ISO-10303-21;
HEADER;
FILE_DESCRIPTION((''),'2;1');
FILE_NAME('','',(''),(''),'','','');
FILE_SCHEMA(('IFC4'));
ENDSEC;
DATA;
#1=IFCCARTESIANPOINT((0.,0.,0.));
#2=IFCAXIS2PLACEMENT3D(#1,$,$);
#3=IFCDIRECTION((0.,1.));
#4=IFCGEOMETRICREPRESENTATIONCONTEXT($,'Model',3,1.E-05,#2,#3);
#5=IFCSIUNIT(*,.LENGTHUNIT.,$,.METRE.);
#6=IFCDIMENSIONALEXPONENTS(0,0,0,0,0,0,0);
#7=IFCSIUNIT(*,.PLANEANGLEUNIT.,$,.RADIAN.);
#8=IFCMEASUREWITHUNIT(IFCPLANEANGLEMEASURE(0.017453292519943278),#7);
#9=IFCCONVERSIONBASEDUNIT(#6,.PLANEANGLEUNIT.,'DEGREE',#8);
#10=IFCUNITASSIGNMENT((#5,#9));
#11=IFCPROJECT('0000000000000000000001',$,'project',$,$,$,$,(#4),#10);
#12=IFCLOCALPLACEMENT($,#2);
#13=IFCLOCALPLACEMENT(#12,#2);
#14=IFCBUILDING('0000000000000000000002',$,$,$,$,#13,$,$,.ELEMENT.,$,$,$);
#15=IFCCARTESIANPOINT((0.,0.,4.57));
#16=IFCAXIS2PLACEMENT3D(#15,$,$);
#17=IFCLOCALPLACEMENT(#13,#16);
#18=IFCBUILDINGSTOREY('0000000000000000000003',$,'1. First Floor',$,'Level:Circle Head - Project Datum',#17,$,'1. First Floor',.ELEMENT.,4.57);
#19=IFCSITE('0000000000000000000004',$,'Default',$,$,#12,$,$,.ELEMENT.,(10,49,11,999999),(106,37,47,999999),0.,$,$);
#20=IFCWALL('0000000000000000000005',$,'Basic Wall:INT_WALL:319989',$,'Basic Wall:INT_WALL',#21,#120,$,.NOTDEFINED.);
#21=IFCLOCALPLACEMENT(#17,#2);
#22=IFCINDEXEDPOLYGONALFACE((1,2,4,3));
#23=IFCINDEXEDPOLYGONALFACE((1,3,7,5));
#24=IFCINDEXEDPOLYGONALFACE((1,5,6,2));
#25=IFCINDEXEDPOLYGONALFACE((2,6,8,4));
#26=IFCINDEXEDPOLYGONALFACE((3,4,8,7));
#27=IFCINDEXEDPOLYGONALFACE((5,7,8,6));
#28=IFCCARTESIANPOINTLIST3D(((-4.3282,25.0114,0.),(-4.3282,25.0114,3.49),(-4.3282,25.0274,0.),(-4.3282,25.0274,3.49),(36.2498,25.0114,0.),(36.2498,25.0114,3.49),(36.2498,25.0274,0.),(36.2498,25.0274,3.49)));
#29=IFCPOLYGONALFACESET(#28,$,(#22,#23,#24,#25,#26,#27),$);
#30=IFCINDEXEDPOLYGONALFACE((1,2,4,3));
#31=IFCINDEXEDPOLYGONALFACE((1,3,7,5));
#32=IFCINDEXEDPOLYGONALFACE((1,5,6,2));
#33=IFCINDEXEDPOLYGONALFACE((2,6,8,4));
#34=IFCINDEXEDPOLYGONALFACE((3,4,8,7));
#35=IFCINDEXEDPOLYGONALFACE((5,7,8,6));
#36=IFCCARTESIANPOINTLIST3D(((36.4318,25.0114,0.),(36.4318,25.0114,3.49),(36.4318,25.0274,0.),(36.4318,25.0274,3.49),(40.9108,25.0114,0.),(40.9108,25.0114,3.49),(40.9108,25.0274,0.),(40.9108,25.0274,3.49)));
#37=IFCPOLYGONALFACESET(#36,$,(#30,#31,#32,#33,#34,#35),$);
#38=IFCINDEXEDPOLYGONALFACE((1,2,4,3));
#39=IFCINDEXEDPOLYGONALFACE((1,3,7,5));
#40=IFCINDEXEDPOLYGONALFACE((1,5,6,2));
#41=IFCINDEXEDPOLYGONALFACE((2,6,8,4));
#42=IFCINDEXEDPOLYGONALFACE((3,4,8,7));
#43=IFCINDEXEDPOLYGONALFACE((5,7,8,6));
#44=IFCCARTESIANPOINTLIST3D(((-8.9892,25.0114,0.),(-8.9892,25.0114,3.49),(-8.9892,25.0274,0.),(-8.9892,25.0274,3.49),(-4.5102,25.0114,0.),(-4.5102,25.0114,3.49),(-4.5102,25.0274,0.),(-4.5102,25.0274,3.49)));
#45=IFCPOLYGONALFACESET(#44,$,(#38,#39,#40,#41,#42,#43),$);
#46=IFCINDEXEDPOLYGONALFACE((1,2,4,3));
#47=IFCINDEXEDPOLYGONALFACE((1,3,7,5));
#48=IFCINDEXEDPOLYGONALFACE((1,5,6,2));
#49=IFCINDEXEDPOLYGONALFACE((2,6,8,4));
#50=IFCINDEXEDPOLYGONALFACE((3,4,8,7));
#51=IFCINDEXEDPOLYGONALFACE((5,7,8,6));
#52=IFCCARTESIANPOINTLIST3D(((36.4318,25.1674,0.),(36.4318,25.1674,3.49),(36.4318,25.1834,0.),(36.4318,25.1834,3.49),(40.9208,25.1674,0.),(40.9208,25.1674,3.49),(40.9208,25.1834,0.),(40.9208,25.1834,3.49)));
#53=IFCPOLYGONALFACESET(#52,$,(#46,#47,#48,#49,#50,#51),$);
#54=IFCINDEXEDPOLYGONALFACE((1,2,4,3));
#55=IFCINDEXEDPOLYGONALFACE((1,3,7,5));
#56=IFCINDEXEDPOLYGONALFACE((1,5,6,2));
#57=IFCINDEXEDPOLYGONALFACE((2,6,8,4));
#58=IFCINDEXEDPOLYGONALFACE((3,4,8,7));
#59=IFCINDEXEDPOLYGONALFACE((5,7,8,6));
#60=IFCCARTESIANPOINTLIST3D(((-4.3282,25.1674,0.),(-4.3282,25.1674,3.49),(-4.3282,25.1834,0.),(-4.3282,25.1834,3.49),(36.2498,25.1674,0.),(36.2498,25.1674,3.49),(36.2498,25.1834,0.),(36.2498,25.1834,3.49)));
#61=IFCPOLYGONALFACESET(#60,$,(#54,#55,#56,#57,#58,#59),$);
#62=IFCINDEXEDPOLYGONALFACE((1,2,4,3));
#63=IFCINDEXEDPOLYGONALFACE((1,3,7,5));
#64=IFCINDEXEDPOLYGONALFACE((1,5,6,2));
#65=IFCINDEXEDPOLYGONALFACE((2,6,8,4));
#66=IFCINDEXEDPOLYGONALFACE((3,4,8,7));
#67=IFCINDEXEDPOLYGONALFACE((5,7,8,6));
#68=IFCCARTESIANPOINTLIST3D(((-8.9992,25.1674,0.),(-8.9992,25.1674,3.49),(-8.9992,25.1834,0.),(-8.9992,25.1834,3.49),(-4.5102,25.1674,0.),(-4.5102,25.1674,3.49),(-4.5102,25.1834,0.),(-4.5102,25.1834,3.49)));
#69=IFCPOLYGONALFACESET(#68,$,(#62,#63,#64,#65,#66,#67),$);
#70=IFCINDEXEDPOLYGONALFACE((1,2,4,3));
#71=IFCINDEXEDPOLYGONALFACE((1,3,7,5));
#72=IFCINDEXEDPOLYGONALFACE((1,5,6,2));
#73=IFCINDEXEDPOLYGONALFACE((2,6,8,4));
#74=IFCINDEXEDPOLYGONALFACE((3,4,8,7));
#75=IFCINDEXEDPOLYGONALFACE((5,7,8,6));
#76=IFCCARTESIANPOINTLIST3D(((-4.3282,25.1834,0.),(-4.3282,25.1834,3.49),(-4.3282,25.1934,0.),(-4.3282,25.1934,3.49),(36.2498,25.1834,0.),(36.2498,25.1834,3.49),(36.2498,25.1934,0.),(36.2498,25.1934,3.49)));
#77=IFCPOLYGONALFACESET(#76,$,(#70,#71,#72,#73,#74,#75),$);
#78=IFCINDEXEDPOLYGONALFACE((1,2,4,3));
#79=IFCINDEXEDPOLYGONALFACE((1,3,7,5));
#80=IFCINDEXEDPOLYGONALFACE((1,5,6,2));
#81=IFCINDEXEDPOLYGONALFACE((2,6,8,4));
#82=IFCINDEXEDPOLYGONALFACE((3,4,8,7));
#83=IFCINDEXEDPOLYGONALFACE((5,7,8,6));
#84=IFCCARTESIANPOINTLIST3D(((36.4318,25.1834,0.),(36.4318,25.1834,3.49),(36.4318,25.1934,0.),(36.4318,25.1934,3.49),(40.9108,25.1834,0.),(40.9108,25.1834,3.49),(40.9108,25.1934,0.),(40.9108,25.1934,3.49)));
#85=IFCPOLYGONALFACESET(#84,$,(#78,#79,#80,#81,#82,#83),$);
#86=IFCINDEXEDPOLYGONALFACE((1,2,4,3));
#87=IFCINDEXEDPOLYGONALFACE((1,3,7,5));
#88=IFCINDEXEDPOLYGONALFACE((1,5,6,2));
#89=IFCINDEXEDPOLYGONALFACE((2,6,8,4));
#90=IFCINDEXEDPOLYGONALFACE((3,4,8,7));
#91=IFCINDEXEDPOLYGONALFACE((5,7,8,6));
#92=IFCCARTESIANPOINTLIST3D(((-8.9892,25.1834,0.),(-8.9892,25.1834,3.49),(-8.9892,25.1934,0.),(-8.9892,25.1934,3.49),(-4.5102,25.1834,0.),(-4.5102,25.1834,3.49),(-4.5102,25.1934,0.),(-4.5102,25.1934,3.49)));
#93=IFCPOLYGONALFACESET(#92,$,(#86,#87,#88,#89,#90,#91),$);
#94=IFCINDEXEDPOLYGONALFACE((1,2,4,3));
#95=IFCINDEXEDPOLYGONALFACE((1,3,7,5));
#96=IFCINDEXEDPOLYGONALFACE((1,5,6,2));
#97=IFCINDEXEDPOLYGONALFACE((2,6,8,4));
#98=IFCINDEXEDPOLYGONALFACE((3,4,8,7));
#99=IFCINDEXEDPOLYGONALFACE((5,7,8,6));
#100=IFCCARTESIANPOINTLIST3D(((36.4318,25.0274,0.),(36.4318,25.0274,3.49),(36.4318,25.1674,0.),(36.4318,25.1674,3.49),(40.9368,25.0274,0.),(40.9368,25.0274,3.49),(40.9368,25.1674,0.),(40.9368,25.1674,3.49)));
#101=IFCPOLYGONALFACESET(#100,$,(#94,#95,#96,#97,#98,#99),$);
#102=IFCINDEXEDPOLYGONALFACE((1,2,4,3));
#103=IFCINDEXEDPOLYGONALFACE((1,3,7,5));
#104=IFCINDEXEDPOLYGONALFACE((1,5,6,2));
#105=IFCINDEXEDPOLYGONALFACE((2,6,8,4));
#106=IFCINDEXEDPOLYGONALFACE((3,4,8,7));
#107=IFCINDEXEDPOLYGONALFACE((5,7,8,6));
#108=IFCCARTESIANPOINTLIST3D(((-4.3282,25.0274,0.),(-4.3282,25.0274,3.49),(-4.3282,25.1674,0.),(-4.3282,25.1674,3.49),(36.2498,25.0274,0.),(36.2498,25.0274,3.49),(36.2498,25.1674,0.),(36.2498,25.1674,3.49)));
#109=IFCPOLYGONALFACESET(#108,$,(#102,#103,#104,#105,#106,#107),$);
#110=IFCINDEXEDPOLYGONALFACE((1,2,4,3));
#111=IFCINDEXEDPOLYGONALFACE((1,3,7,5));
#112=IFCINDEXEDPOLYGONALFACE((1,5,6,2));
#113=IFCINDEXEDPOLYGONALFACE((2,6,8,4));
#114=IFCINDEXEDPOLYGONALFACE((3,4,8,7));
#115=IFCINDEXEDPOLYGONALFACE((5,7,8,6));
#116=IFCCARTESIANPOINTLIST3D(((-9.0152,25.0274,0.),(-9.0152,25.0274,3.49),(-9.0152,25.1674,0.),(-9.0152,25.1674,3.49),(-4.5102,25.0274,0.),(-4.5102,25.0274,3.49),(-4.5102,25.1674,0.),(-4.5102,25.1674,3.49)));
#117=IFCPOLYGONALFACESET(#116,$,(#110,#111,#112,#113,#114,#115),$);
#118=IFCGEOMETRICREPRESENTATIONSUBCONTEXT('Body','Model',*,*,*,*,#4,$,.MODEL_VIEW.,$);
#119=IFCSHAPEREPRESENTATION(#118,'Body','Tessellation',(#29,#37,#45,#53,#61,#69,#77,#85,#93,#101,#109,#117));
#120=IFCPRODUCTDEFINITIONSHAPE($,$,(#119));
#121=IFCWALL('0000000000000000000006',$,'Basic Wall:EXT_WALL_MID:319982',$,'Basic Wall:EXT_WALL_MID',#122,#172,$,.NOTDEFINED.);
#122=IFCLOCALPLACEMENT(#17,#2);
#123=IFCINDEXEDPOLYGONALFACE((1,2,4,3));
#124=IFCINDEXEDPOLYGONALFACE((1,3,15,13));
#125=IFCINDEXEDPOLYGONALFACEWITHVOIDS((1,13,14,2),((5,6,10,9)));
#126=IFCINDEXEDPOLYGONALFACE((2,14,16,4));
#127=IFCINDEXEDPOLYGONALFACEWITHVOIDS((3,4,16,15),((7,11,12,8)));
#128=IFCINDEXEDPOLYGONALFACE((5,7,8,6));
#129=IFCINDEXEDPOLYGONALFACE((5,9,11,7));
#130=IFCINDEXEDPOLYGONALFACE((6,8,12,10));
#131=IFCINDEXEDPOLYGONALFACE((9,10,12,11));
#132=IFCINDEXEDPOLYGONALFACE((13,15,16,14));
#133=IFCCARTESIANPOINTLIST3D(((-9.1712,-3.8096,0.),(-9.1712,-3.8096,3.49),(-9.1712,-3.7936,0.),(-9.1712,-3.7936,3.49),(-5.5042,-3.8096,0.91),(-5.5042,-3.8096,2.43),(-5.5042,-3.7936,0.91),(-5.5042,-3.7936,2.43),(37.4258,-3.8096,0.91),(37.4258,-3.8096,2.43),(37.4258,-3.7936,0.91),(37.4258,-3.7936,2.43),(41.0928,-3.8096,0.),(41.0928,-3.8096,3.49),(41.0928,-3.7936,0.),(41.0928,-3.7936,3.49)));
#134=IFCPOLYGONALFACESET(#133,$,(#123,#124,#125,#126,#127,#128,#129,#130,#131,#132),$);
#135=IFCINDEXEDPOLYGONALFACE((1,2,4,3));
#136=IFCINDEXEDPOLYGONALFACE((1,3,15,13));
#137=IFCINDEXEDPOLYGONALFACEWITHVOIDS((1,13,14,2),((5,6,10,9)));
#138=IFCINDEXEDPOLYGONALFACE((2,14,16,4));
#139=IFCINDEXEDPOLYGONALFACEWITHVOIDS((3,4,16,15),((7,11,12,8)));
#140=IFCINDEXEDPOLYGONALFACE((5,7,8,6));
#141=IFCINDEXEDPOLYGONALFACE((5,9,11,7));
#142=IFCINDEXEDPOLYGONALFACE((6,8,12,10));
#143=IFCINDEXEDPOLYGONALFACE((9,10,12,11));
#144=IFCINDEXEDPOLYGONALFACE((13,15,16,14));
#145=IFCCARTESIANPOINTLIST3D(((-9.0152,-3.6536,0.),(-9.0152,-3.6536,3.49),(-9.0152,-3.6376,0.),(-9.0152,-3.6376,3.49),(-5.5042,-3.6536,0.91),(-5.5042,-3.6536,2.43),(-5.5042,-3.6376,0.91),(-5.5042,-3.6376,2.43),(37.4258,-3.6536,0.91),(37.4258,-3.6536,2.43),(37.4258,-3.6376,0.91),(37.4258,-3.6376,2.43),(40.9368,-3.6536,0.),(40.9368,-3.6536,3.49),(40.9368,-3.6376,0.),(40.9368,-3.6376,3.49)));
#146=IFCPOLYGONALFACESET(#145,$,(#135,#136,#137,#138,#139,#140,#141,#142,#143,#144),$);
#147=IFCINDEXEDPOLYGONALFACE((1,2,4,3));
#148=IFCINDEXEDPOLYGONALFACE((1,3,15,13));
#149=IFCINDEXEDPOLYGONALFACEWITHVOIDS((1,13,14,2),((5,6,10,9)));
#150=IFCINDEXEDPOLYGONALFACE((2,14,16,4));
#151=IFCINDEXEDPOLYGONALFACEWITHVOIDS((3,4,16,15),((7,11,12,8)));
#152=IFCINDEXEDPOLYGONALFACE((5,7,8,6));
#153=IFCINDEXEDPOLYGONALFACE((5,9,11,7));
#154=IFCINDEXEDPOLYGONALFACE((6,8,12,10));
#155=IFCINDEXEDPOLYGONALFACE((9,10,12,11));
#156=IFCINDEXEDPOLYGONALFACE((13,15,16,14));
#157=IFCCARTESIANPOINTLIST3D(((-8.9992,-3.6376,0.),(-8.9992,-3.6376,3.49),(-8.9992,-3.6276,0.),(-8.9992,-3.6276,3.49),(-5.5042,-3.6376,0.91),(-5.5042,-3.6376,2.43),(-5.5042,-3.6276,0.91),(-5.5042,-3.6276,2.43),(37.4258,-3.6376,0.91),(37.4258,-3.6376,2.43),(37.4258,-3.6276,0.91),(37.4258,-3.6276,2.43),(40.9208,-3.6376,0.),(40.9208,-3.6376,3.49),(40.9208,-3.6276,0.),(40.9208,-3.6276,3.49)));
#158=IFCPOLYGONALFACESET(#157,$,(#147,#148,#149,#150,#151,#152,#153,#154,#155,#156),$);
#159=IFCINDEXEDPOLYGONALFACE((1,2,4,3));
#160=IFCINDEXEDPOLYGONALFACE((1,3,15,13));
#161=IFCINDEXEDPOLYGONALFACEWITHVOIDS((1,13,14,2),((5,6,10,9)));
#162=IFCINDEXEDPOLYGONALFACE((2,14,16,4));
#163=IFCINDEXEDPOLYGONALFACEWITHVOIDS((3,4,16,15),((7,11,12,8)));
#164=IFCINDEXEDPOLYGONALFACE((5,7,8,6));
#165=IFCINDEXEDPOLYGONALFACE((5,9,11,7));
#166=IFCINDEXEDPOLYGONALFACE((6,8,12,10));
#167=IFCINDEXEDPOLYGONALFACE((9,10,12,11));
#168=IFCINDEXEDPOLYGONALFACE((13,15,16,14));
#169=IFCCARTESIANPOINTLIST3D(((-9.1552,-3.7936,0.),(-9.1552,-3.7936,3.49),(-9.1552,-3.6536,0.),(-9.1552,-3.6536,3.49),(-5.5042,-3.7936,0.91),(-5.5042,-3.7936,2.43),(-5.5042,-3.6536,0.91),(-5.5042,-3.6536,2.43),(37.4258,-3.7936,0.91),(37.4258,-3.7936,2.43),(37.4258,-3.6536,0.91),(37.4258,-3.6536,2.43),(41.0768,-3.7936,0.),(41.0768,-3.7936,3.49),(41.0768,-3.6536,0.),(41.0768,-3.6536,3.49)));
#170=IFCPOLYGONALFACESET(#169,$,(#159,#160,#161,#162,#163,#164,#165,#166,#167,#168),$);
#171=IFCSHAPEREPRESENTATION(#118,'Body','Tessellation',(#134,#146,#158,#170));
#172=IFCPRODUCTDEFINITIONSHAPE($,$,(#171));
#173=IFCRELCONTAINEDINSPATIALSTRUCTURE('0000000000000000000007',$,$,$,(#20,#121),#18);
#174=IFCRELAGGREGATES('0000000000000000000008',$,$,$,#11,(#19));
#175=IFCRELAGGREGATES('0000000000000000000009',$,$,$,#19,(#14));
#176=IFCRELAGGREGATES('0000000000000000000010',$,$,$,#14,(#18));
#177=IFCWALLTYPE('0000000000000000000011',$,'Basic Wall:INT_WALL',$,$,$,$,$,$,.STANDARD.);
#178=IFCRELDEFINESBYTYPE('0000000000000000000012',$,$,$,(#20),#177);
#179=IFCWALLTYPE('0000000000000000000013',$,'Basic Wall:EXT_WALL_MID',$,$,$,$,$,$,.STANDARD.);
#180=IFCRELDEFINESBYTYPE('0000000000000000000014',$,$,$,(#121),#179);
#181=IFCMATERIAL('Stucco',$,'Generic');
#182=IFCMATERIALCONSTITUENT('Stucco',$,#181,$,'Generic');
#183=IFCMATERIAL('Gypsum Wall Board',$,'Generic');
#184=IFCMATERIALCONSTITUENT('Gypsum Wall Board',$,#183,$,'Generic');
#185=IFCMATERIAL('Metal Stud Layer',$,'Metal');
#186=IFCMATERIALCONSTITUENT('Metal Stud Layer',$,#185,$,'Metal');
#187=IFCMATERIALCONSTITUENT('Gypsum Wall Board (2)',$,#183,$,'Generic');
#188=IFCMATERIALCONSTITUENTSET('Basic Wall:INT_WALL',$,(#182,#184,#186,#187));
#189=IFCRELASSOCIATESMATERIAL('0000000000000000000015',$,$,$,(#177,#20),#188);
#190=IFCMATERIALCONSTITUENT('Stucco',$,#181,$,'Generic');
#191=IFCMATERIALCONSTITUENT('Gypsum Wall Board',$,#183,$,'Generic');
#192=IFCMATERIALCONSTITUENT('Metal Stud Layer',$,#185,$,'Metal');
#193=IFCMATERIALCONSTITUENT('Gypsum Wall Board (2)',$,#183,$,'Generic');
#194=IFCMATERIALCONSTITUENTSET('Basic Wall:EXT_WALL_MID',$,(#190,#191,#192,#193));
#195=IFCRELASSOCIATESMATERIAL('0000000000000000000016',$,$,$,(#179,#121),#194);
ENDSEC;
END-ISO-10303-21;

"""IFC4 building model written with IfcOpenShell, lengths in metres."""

from ifc_helpers import new_model, entity, si_unit, converted_unit, direction, frame, origin, place, context, subcontext, project, spatial, indexed_curve, outline, extrude, material, constituent, constituent_set, type_object, element, save


model = new_model("IFC4")

# Units and contexts
model_context = context("Model", 3, precision=1e-05, world=origin(), true_north=direction((0.0, 1.0)))
body_context = subcontext(model_context, "Body", "Model", "MODEL_VIEW")
ifc_project = project(units=[si_unit("LENGTHUNIT", "METRE"), converted_unit("PLANEANGLEUNIT", "DEGREE", entity("IfcPlaneAngleMeasure", 0.017453292519943278), si_unit("PLANEANGLEUNIT", "RADIAN"), dimensions=[0, 0, 0, 0, 0, 0, 0])], contexts=[model_context])

# Site, building, storey
site_placement = place(None, origin())
site = spatial("IfcSite", under=ifc_project, at=site_placement, Name="Default", CompositionType="ELEMENT", RefLatitude=(10, 49, 11, 999999), RefLongitude=(106, 37, 47, 999999), RefElevation=0.0)
building_placement = place(site_placement, origin())
building = spatial("IfcBuilding", under=site, at=building_placement, CompositionType="ELEMENT")
storey_placement = place(building_placement, frame((0.0, 0.0, 4.57)))
storey = spatial("IfcBuildingStorey", under=building, at=storey_placement, Name="1. First Floor", ObjectType="Level:Circle Head - Project Datum", LongName="1. First Floor", CompositionType="ELEMENT", Elevation=4.57)

# Wall
ifc_material_1 = material(Name="Stucco", Category="Generic")
ifc_constituent_1 = constituent(ifc_material_1, Name="Stucco", Category="Generic")
ifc_material_2 = material(Name="Gypsum Wall Board", Category="Generic")
ifc_constituent_2 = constituent(ifc_material_2, Name="Gypsum Wall Board", Category="Generic")
ifc_material_3 = material(Name="Metal Stud Layer", Category="Metal")
ifc_constituent_3 = constituent(ifc_material_3, Name="Metal Stud Layer", Category="Metal")
ifc_constituent_4 = constituent(ifc_material_2, Name="Gypsum Wall Board (2)", Category="Generic")
ifc_constituent_set_1 = constituent_set(constituents=[ifc_constituent_1, ifc_constituent_2, ifc_constituent_3, ifc_constituent_4], Name="Basic Wall:INT_WALL")
wall_type_1 = type_object("IfcWallType", Name="Basic Wall:INT_WALL", PredefinedType="STANDARD", material=ifc_constituent_set_1)
wall_1_placement = place(storey_placement, frame((-8.9892, 25.1024, 0.0)))
element("IfcWall", 1, at=wall_1_placement, inside=storey, type_object=wall_type_1, material=ifc_constituent_set_1, Name="Basic Wall:INT_WALL:319989", ObjectType="Basic Wall:INT_WALL", PredefinedType="NOTDEFINED", context=body_context, shape_type="SweptSolid", body=[
    extrude(outline(indexed_curve([(-0.008, -20.289), (0.008, -20.289), (0.008, 20.289), (-0.008, 20.289), (-0.008, -20.289)], self_intersect=False)), frame((24.95, -0.083, 0.0), z_axis=(0.0, 0.0, 1.0), x_axis=(0.0, 1.0, 0.0)), (0.0, 0.0, 1.0), 3.49),
    extrude(outline(indexed_curve([(-0.008, -2.2395), (0.008, -2.2395), (0.008, 2.2395), (-0.008, 2.2395), (-0.008, -2.2395)], self_intersect=False)), frame((47.6605, -0.083, 0.0), z_axis=(0.0, 0.0, 1.0), x_axis=(0.0, 1.0, 0.0)), (0.0, 0.0, 1.0), 3.49),
    extrude(outline(indexed_curve([(-0.008, -2.2395), (0.008, -2.2395), (0.008, 2.2395), (-0.008, 2.2395), (-0.008, -2.2395)], self_intersect=False)), frame((2.2395, -0.083, 0.0), z_axis=(0.0, 0.0, 1.0), x_axis=(0.0, 1.0, 0.0)), (0.0, 0.0, 1.0), 3.49),
    extrude(outline(indexed_curve([(-2.2445, -0.008), (2.2445, -0.008), (2.2445, 0.008), (-2.2445, 0.008), (-2.2445, -0.008)], self_intersect=False)), frame((47.6655, 0.073, 0.0), z_axis=(0.0, 0.0, 1.0), x_axis=(-1.0, 0.0, 0.0)), (0.0, 0.0, 1.0), 3.49),
    extrude(outline(indexed_curve([(-20.289, -0.008), (20.289, -0.008), (20.289, 0.008), (-20.289, 0.008), (-20.289, -0.008)], self_intersect=False)), frame((24.95, 0.073, 0.0)), (0.0, 0.0, 1.0), 3.49),
    extrude(outline(indexed_curve([(-2.2445, -0.008), (2.2445, -0.008), (2.2445, 0.008), (-2.2445, 0.008), (-2.2445, -0.008)], self_intersect=False)), frame((2.2345, 0.073, 0.0)), (0.0, 0.0, 1.0), 3.49),
    extrude(outline(indexed_curve([(-0.005, -20.289), (0.005, -20.289), (0.005, 20.289), (-0.005, 20.289), (-0.005, -20.289)], self_intersect=False)), frame((24.95, 0.086, 0.0), z_axis=(0.0, 0.0, 1.0), x_axis=(0.0, -1.0, 0.0)), (0.0, 0.0, 1.0), 3.49),
    extrude(outline(indexed_curve([(-0.005, -2.2395), (0.005, -2.2395), (0.005, 2.2395), (-0.005, 2.2395), (-0.005, -2.2395)], self_intersect=False)), frame((47.6605, 0.086, 0.0), z_axis=(0.0, 0.0, 1.0), x_axis=(0.0, -1.0, 0.0)), (0.0, 0.0, 1.0), 3.49),
    extrude(outline(indexed_curve([(-0.005, -2.2395), (0.005, -2.2395), (0.005, 2.2395), (-0.005, 2.2395), (-0.005, -2.2395)], self_intersect=False)), frame((2.2395, 0.086, 0.0), z_axis=(0.0, 0.0, 1.0), x_axis=(0.0, -1.0, 0.0)), (0.0, 0.0, 1.0), 3.49),
    extrude(outline(indexed_curve([(-2.2525, -0.07), (2.2525, -0.07), (2.2525, 0.07), (-2.2525, 0.07), (-2.2525, -0.07)], self_intersect=False)), frame((47.6735, -0.005, 0.0), z_axis=(0.0, 0.0, 1.0), x_axis=(-1.0, 0.0, 0.0)), (0.0, 0.0, 1.0), 3.49),
    extrude(outline(indexed_curve([(-20.289, -0.07), (20.289, -0.07), (20.289, 0.07), (-20.289, 0.07), (-20.289, -0.07)], self_intersect=False)), frame((24.95, -0.005, 0.0)), (0.0, 0.0, 1.0), 3.49),
    extrude(outline(indexed_curve([(-2.2525, -0.07), (2.2525, -0.07), (2.2525, 0.07), (-2.2525, 0.07), (-2.2525, -0.07)], self_intersect=False)), frame((2.2265, -0.005, 0.0)), (0.0, 0.0, 1.0), 3.49),
])

# Wall, opening
ifc_constituent_5 = constituent(ifc_material_1, Name="Stucco", Category="Generic")
ifc_constituent_6 = constituent(ifc_material_2, Name="Gypsum Wall Board", Category="Generic")
ifc_constituent_7 = constituent(ifc_material_3, Name="Metal Stud Layer", Category="Metal")
ifc_constituent_8 = constituent(ifc_material_2, Name="Gypsum Wall Board (2)", Category="Generic")
ifc_constituent_set_2 = constituent_set(constituents=[ifc_constituent_5, ifc_constituent_6, ifc_constituent_7, ifc_constituent_8], Name="Basic Wall:EXT_WALL_MID")
wall_type_2 = type_object("IfcWallType", Name="Basic Wall:EXT_WALL_MID", PredefinedType="STANDARD", material=ifc_constituent_set_2)
wall_2_placement = place(storey_placement, frame((-9.1712, -3.7186, 0.0)))
wall_2 = element("IfcWall", 2, at=wall_2_placement, inside=storey, type_object=wall_type_2, material=ifc_constituent_set_2, Name="Basic Wall:EXT_WALL_MID:319982", ObjectType="Basic Wall:EXT_WALL_MID", PredefinedType="NOTDEFINED", context=body_context, shape_type="SweptSolid", body=[
    extrude(outline(indexed_curve([(-1.745, -25.132), (1.745, -25.132), (1.745, 25.132), (-1.745, 25.132), (-1.745, -25.132)], self_intersect=False), holes=[indexed_curve([(0.685, 21.465), (0.685, -21.465), (-0.835, -21.465), (-0.835, 21.465), (0.685, 21.465)], self_intersect=False)]), frame((25.132, -0.091, 1.745), z_axis=(0.0, 1.0, 0.0), x_axis=(0.0, 0.0, 1.0)), (0.0, 0.0, 1.0), 0.016),
    extrude(outline(indexed_curve([(-1.745, -24.976), (1.745, -24.976), (1.745, 24.976), (-1.745, 24.976), (-1.745, -24.976)], self_intersect=False), holes=[indexed_curve([(0.685, 21.465), (0.685, -21.465), (-0.835, -21.465), (-0.835, 21.465), (0.685, 21.465)], self_intersect=False)]), frame((25.132, 0.065, 1.745), z_axis=(0.0, 1.0, 0.0), x_axis=(0.0, 0.0, 1.0)), (0.0, 0.0, 1.0), 0.016),
    extrude(outline(indexed_curve([(-1.745, -24.96), (1.745, -24.96), (1.745, 24.96), (-1.745, 24.96), (-1.745, -24.96)], self_intersect=False), holes=[indexed_curve([(0.685, 21.465), (0.685, -21.465), (-0.835, -21.465), (-0.835, 21.465), (0.685, 21.465)], self_intersect=False)]), frame((25.132, 0.081, 1.745), z_axis=(0.0, 1.0, 0.0), x_axis=(0.0, 0.0, 1.0)), (0.0, 0.0, 1.0), 0.01),
    extrude(outline(indexed_curve([(-1.745, -25.116), (1.745, -25.116), (1.745, 25.116), (-1.745, 25.116), (-1.745, -25.116)], self_intersect=False), holes=[indexed_curve([(0.685, 21.465), (0.685, -21.465), (-0.835, -21.465), (-0.835, 21.465), (0.685, 21.465)], self_intersect=False)]), frame((25.132, -0.075, 1.745), z_axis=(0.0, 1.0, 0.0), x_axis=(0.0, 0.0, 1.0)), (0.0, 0.0, 1.0), 0.14),
])
opening_1_placement = place(wall_2_placement, frame((46.597, 0.091, 0.91)))
element("IfcOpeningElement", 3, at=opening_1_placement, cuts=wall_2, PredefinedType="OPENING", context=body_context, shape_type="SweptSolid", body=[
    extrude(outline(indexed_curve([(1.52, 0.0), (1.52, 42.93), (0.0, 42.93), (0.0, 0.0), (1.52, 0.0)], self_intersect=False)), frame((0.0, 0.0, 0.0), z_axis=(0.0, -1.0, 0.0), x_axis=(0.0, 0.0, 1.0)), (0.0, 0.0, 1.0), 0.182),
])

save(model, "model.ifc")
